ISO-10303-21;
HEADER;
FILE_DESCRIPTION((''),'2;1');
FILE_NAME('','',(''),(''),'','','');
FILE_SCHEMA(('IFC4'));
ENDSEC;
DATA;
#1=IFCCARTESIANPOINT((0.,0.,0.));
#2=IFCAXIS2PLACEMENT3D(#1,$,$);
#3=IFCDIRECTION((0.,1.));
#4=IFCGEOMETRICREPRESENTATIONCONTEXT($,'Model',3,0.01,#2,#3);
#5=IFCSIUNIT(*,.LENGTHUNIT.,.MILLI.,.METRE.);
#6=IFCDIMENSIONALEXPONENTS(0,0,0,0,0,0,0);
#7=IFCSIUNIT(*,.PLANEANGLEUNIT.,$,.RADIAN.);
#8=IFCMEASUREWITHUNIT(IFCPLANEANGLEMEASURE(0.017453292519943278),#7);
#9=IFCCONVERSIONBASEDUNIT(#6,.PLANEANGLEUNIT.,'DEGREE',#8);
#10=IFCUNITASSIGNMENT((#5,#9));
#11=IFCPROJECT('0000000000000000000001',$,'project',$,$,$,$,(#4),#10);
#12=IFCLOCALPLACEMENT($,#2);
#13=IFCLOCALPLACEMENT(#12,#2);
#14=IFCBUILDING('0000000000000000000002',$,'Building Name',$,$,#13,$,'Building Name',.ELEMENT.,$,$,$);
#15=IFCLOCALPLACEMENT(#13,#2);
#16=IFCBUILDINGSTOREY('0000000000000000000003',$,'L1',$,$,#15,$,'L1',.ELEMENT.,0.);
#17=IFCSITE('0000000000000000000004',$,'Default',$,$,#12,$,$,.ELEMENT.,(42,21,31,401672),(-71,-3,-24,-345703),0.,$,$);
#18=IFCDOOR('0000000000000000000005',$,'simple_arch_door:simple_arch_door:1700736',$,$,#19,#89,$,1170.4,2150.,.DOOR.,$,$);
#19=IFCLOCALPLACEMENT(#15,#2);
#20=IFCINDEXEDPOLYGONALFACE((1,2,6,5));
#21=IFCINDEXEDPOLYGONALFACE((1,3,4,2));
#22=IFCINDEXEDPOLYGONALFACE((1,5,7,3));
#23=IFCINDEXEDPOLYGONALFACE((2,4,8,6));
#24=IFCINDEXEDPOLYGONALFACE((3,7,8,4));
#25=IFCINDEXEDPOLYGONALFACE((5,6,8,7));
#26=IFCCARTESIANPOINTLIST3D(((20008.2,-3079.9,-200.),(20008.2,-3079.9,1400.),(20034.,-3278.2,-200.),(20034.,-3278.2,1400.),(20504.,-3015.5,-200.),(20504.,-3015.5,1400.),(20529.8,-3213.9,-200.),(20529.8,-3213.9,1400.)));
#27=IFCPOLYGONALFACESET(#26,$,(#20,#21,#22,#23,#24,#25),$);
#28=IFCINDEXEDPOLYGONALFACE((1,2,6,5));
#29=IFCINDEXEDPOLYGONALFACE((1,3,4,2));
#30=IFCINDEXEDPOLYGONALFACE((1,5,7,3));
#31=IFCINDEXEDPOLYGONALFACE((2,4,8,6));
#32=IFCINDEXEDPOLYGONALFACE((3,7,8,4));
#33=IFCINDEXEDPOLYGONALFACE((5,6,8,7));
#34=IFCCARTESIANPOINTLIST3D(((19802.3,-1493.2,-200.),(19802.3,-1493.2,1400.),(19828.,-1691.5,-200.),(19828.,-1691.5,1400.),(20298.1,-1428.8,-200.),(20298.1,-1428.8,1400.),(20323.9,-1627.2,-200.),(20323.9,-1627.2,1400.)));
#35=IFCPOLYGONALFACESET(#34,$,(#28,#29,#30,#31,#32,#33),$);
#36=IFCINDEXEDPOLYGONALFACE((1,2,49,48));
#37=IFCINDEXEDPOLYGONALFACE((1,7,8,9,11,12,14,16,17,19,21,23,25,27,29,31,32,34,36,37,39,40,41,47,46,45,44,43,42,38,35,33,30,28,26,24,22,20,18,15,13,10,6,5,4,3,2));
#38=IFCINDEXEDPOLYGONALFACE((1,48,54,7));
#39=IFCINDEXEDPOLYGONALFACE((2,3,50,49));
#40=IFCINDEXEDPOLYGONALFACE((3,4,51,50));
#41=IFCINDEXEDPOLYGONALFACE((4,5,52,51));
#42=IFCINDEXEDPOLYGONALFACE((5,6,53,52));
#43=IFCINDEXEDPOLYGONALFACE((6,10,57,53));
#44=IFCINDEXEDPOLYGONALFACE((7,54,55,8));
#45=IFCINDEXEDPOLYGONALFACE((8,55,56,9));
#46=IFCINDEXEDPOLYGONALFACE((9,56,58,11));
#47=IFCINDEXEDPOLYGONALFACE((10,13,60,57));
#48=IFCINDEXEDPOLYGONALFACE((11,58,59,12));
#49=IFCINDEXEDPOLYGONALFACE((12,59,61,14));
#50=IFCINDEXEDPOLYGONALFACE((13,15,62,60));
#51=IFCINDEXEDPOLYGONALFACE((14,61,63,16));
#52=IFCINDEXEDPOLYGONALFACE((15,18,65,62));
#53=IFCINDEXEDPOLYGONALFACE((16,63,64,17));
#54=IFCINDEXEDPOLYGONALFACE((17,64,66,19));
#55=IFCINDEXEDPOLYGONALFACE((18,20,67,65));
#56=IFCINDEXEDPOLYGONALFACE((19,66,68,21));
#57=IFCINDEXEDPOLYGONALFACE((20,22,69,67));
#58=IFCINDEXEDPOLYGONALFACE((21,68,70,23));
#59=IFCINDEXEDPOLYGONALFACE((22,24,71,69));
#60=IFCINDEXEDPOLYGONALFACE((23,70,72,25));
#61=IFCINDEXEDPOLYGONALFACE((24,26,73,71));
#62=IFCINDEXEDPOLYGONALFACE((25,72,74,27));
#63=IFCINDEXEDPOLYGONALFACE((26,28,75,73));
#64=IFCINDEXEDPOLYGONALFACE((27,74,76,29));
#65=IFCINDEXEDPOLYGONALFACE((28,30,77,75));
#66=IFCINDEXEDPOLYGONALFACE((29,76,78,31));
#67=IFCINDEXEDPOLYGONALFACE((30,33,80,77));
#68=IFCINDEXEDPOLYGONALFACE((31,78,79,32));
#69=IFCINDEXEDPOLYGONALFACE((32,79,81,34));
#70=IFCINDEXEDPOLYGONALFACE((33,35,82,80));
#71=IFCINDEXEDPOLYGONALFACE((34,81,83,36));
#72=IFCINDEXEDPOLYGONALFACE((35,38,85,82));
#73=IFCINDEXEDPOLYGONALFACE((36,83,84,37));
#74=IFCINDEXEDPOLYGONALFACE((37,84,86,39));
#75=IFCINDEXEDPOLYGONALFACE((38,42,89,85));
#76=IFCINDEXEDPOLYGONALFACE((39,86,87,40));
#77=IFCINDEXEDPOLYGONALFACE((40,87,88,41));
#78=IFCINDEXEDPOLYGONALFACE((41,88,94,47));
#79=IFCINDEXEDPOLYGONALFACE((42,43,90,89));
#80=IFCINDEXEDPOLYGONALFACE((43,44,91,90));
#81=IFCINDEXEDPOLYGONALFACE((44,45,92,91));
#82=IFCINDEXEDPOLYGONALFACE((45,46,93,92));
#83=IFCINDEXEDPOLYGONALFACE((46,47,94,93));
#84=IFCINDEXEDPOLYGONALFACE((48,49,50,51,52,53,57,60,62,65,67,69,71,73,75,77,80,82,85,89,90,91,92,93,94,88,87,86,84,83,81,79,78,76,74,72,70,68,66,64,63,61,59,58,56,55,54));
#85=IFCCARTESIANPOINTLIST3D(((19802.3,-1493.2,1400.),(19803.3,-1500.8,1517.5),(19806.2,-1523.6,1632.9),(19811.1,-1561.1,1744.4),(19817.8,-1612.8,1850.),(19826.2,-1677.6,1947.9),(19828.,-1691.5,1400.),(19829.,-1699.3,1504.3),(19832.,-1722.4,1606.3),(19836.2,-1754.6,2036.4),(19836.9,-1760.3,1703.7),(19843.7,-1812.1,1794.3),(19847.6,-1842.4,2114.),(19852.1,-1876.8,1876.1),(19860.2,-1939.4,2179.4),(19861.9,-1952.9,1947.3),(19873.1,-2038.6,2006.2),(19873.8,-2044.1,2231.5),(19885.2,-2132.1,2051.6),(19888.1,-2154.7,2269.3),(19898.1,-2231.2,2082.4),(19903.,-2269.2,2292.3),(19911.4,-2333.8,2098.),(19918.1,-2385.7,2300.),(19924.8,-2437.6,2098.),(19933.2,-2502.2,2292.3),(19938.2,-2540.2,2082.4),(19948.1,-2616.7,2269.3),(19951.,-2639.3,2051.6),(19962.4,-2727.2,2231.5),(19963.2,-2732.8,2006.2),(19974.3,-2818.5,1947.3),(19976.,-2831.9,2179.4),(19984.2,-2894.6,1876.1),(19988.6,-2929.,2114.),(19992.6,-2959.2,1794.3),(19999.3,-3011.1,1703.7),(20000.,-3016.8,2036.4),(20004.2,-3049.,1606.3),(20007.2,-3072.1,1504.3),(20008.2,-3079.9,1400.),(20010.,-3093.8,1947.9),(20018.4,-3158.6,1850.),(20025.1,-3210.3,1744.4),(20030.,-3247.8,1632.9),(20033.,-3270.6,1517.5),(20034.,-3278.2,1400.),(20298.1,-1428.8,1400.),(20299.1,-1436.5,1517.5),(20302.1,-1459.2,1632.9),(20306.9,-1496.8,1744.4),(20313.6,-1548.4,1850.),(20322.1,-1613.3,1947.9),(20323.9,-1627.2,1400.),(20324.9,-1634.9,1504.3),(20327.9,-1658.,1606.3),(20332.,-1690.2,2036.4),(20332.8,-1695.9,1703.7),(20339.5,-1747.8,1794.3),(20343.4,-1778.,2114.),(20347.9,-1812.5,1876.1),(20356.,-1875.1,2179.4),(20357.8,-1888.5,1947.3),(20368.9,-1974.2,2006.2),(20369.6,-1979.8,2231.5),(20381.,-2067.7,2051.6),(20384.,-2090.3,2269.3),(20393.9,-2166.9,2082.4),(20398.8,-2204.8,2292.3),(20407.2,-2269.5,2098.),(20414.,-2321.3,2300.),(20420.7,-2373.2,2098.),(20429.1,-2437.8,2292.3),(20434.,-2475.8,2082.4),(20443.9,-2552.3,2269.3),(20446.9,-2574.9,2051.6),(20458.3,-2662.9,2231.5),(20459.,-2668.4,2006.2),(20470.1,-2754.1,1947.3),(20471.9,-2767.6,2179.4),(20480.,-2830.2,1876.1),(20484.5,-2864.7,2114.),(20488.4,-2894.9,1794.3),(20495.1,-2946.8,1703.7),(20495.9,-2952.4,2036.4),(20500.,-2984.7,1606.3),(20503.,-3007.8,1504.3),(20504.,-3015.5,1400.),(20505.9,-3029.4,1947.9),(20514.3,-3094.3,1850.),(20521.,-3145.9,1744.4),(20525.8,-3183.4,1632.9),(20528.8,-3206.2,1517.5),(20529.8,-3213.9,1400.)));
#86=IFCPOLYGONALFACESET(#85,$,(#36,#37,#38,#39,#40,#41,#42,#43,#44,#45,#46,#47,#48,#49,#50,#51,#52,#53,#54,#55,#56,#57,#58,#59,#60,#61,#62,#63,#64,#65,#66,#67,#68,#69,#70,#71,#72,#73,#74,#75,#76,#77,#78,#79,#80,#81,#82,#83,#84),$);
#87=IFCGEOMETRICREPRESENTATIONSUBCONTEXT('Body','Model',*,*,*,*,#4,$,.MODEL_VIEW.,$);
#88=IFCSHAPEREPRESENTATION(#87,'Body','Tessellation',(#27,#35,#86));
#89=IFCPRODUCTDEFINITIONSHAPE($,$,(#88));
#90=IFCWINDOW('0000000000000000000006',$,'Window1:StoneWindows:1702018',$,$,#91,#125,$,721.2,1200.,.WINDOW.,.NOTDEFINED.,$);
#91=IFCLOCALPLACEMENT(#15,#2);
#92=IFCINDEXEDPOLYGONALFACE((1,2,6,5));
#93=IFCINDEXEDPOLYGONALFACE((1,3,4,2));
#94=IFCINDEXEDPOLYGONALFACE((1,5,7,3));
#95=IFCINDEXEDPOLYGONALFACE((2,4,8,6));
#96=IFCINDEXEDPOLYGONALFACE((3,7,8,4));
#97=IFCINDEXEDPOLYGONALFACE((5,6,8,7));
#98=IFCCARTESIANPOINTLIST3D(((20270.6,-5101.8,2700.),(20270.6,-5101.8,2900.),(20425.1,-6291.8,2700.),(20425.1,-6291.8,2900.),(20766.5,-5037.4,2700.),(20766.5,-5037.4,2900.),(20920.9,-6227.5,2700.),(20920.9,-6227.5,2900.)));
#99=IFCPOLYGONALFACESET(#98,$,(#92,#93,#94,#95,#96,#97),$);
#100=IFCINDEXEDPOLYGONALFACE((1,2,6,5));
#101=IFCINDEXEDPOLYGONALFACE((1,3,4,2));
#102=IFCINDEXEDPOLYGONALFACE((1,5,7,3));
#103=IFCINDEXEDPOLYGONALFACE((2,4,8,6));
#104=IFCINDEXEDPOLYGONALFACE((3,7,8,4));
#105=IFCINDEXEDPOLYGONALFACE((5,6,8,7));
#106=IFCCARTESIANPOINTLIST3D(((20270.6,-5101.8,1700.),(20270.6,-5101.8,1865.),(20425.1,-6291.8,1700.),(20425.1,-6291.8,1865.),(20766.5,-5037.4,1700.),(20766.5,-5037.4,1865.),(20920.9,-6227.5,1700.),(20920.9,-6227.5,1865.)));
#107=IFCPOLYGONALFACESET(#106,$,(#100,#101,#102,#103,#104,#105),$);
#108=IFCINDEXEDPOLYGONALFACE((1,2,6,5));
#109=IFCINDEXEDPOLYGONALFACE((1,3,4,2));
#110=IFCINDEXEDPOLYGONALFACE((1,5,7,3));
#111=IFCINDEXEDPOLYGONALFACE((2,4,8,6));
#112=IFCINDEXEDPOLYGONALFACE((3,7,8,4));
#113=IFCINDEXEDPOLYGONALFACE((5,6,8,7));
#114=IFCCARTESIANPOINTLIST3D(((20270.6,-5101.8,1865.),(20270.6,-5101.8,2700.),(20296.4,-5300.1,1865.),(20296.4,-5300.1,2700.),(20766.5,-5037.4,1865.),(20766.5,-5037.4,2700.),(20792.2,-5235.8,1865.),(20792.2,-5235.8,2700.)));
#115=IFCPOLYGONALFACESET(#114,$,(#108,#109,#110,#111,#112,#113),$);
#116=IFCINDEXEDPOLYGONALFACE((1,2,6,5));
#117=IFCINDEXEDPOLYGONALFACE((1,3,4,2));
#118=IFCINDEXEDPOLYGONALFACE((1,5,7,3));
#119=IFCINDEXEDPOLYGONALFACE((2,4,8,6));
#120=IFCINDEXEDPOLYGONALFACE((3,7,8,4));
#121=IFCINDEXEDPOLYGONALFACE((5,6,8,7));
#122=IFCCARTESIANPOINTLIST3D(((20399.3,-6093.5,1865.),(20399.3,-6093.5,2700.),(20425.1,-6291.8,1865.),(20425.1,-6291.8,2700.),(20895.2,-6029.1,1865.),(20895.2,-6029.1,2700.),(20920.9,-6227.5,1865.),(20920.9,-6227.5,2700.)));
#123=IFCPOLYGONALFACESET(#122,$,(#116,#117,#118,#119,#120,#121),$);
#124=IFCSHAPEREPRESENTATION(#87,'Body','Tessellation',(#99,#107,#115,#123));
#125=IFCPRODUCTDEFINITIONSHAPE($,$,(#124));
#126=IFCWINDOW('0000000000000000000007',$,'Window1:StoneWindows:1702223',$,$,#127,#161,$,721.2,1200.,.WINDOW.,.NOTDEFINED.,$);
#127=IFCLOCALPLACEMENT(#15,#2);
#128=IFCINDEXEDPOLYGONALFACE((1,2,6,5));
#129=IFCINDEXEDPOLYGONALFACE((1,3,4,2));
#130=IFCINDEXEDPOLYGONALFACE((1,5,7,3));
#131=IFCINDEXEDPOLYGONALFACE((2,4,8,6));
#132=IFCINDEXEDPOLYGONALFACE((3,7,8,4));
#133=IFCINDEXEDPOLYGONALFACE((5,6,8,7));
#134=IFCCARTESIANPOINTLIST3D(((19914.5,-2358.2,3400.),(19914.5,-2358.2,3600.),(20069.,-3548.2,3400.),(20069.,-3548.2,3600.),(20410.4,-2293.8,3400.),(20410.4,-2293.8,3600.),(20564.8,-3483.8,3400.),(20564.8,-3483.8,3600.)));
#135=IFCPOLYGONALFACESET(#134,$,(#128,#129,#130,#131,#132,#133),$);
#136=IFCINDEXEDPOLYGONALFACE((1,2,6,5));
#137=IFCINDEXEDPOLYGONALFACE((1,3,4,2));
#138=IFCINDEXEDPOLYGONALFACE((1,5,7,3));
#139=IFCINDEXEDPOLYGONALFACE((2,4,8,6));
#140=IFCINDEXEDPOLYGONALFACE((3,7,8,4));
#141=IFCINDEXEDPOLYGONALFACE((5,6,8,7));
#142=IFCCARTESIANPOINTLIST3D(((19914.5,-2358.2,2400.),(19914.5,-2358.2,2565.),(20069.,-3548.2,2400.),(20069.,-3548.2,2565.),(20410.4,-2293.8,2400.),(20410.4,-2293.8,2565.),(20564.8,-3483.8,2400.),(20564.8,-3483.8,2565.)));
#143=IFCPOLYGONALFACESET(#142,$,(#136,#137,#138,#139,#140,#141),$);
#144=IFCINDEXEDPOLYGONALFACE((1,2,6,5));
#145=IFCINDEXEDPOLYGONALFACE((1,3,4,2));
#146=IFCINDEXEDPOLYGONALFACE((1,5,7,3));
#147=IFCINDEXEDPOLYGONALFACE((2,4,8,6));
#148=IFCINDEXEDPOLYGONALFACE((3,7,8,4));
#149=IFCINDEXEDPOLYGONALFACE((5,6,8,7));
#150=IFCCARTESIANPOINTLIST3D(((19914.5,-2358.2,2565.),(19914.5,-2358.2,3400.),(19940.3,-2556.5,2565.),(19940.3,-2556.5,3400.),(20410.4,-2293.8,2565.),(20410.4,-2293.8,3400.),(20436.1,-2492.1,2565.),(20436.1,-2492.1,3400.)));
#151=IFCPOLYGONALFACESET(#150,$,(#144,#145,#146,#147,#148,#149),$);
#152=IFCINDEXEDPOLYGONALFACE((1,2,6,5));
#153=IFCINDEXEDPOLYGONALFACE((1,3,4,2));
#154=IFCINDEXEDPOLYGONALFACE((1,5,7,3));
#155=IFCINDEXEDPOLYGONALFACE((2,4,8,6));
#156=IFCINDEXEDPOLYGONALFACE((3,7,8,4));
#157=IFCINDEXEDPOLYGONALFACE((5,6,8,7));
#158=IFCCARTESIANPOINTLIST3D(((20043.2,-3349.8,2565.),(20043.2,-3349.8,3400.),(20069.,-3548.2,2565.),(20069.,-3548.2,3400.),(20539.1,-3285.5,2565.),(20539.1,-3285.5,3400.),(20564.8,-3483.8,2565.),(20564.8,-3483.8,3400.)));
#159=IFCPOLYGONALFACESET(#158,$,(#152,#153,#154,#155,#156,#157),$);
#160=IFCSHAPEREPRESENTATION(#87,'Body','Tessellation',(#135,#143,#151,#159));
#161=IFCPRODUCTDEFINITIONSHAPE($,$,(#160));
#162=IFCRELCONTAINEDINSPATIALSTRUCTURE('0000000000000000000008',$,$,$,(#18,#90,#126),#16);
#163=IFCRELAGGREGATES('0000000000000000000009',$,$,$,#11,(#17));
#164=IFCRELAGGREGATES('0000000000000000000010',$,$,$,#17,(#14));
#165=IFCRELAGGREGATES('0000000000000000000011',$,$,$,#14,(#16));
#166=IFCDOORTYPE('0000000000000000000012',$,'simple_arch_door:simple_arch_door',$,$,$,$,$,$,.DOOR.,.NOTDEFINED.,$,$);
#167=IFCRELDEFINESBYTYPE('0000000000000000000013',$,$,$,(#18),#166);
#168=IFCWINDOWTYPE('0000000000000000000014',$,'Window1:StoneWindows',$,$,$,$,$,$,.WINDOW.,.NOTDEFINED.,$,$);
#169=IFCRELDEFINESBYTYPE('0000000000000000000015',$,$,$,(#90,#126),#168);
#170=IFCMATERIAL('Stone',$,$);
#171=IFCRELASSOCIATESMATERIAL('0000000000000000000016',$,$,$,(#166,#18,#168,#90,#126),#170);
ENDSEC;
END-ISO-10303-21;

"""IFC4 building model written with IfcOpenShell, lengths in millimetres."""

from ifc_helpers import new_model, entity, si_unit, converted_unit, direction, frame, origin, place, context, subcontext, project, spatial, line, arc, indexed_curve, outline, extrude, source, transform, mapped, material, type_object, type_shapes, element, save


model = new_model("IFC4")

# Units and contexts
model_context = context("Model", 3, precision=0.01, world=origin(), true_north=direction((0.0, 1.0)))
body_context = subcontext(model_context, "Body", "Model", "MODEL_VIEW")
ifc_project = project(units=[si_unit("LENGTHUNIT", "METRE", prefix="MILLI"), converted_unit("PLANEANGLEUNIT", "DEGREE", entity("IfcPlaneAngleMeasure", 0.017453292519943278), si_unit("PLANEANGLEUNIT", "RADIAN"), dimensions=[0, 0, 0, 0, 0, 0, 0])], contexts=[model_context])

# Site, building, storey
site_placement = place(None, origin())
site = spatial("IfcSite", under=ifc_project, at=site_placement, Name="Default", CompositionType="ELEMENT", RefLatitude=(42, 21, 31, 401672), RefLongitude=(-71, -3, -24, -345703), RefElevation=0.0)
building_placement = place(site_placement, origin())
building = spatial("IfcBuilding", under=site, at=building_placement, Name="Building Name", LongName="Building Name", CompositionType="ELEMENT")
storey_placement = place(building_placement, origin())
storey = spatial("IfcBuildingStorey", under=building, at=storey_placement, Name="L1", LongName="L1", CompositionType="ELEMENT", Elevation=0.0)

# Door
ifc_material_1 = material(Name="Stone")
door_type_1 = type_object("IfcDoorType", Name="simple_arch_door:simple_arch_door", OperationType="NOTDEFINED", PredefinedType="DOOR", material=ifc_material_1)
shared_shape_1 = source(origin(), body_context, "Body", "SweptSolid", [
    extrude(outline(indexed_curve([(-250.0, -100.0), (250.0, -100.0), (250.0, 100.0), (-250.0, 100.0), (-250.0, -100.0)], self_intersect=False)), frame((800.0, 0.0, 0.0), z_axis=(0.0, 0.0, 1.0), x_axis=(0.0, 1.0, 0.0)), (0.0, 0.0, 1.0), 1600.0),
    extrude(outline(indexed_curve([(-250.0, -100.0), (250.0, -100.0), (250.0, 100.0), (-250.0, 100.0), (-250.0, -100.0)], self_intersect=False)), frame((-800.0, 0.0, 0.0), z_axis=(0.0, 0.0, 1.0), x_axis=(0.0, 1.0, 0.0)), (0.0, 0.0, 1.0), 1600.0),
    extrude(outline(indexed_curve([(-900.0, 0.0), (0.0, -900.0), (900.0, 0.0), (700.0, 0.0), (0.0, -700.0), (-700.0, 0.0)], segments=[arc(1, 2, 3), line(3, 4), arc(4, 5, 6), line(6, 1)], self_intersect=False)), frame((0.0, -250.0, 1600.0), z_axis=(0.0, 1.0, 0.0), x_axis=(1.0, 0.0, 0.0)), (0.0, 0.0, 1.0), 500.0),
])
type_shapes(door_type_1, [shared_shape_1])
door_1_placement = place(storey_placement, frame((20166.0, -2353.5, -200.0), z_axis=(0.0, 0.0, 1.0), x_axis=(0.128709, -0.991682, 0.0)))
element("IfcDoor", 1, at=door_1_placement, inside=storey, type_object=door_type_1, material=ifc_material_1, Name="simple_arch_door:simple_arch_door:1700736", OverallHeight=1170.4, OverallWidth=2150.0, PredefinedType="DOOR", context=body_context, shape_type="MappedRepresentation", body=[
    mapped(shared_shape_1, transform((0.0, 0.0, 0.0), scale=1.0)),
])

# Windows
window_type_1 = type_object("IfcWindowType", Name="Window1:StoneWindows", PartitioningType="NOTDEFINED", PredefinedType="WINDOW", material=ifc_material_1)
shared_shape_2 = source(origin(), body_context, "Body", "SweptSolid", [
    extrude(outline(indexed_curve([(-250.0, -600.0), (250.0, -600.0), (250.0, 600.0), (-250.0, 600.0), (-250.0, -600.0)], self_intersect=False)), frame((0.0, 0.0, 1800.0), z_axis=(0.0, 0.0, 1.0), x_axis=(0.0, 1.0, 0.0)), (0.0, 0.0, 1.0), 200.0),
    extrude(outline(indexed_curve([(-250.0, -600.0), (250.0, -600.0), (250.0, 600.0), (-250.0, 600.0), (-250.0, -600.0)], self_intersect=False)), frame((0.0, 0.0, 800.0), z_axis=(0.0, 0.0, 1.0), x_axis=(0.0, 1.0, 0.0)), (0.0, 0.0, 1.0), 165.0),
    extrude(outline(indexed_curve([(-250.0, -100.0), (250.0, -100.0), (250.0, 100.0), (-250.0, 100.0), (-250.0, -100.0)], self_intersect=False)), frame((-500.0, 0.0, 965.0), z_axis=(0.0, 0.0, 1.0), x_axis=(0.0, 1.0, 0.0)), (0.0, 0.0, 1.0), 835.0),
    extrude(outline(indexed_curve([(-250.0, -100.0), (250.0, -100.0), (250.0, 100.0), (-250.0, 100.0), (-250.0, -100.0)], self_intersect=False)), frame((500.0, 0.0, 965.0), z_axis=(0.0, 0.0, 1.0), x_axis=(0.0, 1.0, 0.0)), (0.0, 0.0, 1.0), 835.0),
])
type_shapes(window_type_1, [shared_shape_2])
for number, where, z_axis, x_axis, name in (
    (2, (20595.8, -5664.6, 900.0), (0.0, 0.0, 1.0), (0.128709, -0.991682, 0.0), "Window1:StoneWindows:1702018"),
    (3, (20239.7, -2921.0, 1600.0), (0.0, 0.0, 1.0), (0.128709, -0.991682, 0.0), "Window1:StoneWindows:1702223"),
):
    element("IfcWindow", number, at=place(storey_placement, frame(where, z_axis=z_axis, x_axis=x_axis)), inside=storey, type_object=window_type_1, material=ifc_material_1, Name=name, OverallHeight=721.2, OverallWidth=1200.0, PartitioningType="NOTDEFINED", PredefinedType="WINDOW", context=body_context, shape_type="MappedRepresentation", body=[
        mapped(shared_shape_2, transform((0.0, 0.0, 0.0), scale=1.0)),
    ])

save(model, "model.ifc")
